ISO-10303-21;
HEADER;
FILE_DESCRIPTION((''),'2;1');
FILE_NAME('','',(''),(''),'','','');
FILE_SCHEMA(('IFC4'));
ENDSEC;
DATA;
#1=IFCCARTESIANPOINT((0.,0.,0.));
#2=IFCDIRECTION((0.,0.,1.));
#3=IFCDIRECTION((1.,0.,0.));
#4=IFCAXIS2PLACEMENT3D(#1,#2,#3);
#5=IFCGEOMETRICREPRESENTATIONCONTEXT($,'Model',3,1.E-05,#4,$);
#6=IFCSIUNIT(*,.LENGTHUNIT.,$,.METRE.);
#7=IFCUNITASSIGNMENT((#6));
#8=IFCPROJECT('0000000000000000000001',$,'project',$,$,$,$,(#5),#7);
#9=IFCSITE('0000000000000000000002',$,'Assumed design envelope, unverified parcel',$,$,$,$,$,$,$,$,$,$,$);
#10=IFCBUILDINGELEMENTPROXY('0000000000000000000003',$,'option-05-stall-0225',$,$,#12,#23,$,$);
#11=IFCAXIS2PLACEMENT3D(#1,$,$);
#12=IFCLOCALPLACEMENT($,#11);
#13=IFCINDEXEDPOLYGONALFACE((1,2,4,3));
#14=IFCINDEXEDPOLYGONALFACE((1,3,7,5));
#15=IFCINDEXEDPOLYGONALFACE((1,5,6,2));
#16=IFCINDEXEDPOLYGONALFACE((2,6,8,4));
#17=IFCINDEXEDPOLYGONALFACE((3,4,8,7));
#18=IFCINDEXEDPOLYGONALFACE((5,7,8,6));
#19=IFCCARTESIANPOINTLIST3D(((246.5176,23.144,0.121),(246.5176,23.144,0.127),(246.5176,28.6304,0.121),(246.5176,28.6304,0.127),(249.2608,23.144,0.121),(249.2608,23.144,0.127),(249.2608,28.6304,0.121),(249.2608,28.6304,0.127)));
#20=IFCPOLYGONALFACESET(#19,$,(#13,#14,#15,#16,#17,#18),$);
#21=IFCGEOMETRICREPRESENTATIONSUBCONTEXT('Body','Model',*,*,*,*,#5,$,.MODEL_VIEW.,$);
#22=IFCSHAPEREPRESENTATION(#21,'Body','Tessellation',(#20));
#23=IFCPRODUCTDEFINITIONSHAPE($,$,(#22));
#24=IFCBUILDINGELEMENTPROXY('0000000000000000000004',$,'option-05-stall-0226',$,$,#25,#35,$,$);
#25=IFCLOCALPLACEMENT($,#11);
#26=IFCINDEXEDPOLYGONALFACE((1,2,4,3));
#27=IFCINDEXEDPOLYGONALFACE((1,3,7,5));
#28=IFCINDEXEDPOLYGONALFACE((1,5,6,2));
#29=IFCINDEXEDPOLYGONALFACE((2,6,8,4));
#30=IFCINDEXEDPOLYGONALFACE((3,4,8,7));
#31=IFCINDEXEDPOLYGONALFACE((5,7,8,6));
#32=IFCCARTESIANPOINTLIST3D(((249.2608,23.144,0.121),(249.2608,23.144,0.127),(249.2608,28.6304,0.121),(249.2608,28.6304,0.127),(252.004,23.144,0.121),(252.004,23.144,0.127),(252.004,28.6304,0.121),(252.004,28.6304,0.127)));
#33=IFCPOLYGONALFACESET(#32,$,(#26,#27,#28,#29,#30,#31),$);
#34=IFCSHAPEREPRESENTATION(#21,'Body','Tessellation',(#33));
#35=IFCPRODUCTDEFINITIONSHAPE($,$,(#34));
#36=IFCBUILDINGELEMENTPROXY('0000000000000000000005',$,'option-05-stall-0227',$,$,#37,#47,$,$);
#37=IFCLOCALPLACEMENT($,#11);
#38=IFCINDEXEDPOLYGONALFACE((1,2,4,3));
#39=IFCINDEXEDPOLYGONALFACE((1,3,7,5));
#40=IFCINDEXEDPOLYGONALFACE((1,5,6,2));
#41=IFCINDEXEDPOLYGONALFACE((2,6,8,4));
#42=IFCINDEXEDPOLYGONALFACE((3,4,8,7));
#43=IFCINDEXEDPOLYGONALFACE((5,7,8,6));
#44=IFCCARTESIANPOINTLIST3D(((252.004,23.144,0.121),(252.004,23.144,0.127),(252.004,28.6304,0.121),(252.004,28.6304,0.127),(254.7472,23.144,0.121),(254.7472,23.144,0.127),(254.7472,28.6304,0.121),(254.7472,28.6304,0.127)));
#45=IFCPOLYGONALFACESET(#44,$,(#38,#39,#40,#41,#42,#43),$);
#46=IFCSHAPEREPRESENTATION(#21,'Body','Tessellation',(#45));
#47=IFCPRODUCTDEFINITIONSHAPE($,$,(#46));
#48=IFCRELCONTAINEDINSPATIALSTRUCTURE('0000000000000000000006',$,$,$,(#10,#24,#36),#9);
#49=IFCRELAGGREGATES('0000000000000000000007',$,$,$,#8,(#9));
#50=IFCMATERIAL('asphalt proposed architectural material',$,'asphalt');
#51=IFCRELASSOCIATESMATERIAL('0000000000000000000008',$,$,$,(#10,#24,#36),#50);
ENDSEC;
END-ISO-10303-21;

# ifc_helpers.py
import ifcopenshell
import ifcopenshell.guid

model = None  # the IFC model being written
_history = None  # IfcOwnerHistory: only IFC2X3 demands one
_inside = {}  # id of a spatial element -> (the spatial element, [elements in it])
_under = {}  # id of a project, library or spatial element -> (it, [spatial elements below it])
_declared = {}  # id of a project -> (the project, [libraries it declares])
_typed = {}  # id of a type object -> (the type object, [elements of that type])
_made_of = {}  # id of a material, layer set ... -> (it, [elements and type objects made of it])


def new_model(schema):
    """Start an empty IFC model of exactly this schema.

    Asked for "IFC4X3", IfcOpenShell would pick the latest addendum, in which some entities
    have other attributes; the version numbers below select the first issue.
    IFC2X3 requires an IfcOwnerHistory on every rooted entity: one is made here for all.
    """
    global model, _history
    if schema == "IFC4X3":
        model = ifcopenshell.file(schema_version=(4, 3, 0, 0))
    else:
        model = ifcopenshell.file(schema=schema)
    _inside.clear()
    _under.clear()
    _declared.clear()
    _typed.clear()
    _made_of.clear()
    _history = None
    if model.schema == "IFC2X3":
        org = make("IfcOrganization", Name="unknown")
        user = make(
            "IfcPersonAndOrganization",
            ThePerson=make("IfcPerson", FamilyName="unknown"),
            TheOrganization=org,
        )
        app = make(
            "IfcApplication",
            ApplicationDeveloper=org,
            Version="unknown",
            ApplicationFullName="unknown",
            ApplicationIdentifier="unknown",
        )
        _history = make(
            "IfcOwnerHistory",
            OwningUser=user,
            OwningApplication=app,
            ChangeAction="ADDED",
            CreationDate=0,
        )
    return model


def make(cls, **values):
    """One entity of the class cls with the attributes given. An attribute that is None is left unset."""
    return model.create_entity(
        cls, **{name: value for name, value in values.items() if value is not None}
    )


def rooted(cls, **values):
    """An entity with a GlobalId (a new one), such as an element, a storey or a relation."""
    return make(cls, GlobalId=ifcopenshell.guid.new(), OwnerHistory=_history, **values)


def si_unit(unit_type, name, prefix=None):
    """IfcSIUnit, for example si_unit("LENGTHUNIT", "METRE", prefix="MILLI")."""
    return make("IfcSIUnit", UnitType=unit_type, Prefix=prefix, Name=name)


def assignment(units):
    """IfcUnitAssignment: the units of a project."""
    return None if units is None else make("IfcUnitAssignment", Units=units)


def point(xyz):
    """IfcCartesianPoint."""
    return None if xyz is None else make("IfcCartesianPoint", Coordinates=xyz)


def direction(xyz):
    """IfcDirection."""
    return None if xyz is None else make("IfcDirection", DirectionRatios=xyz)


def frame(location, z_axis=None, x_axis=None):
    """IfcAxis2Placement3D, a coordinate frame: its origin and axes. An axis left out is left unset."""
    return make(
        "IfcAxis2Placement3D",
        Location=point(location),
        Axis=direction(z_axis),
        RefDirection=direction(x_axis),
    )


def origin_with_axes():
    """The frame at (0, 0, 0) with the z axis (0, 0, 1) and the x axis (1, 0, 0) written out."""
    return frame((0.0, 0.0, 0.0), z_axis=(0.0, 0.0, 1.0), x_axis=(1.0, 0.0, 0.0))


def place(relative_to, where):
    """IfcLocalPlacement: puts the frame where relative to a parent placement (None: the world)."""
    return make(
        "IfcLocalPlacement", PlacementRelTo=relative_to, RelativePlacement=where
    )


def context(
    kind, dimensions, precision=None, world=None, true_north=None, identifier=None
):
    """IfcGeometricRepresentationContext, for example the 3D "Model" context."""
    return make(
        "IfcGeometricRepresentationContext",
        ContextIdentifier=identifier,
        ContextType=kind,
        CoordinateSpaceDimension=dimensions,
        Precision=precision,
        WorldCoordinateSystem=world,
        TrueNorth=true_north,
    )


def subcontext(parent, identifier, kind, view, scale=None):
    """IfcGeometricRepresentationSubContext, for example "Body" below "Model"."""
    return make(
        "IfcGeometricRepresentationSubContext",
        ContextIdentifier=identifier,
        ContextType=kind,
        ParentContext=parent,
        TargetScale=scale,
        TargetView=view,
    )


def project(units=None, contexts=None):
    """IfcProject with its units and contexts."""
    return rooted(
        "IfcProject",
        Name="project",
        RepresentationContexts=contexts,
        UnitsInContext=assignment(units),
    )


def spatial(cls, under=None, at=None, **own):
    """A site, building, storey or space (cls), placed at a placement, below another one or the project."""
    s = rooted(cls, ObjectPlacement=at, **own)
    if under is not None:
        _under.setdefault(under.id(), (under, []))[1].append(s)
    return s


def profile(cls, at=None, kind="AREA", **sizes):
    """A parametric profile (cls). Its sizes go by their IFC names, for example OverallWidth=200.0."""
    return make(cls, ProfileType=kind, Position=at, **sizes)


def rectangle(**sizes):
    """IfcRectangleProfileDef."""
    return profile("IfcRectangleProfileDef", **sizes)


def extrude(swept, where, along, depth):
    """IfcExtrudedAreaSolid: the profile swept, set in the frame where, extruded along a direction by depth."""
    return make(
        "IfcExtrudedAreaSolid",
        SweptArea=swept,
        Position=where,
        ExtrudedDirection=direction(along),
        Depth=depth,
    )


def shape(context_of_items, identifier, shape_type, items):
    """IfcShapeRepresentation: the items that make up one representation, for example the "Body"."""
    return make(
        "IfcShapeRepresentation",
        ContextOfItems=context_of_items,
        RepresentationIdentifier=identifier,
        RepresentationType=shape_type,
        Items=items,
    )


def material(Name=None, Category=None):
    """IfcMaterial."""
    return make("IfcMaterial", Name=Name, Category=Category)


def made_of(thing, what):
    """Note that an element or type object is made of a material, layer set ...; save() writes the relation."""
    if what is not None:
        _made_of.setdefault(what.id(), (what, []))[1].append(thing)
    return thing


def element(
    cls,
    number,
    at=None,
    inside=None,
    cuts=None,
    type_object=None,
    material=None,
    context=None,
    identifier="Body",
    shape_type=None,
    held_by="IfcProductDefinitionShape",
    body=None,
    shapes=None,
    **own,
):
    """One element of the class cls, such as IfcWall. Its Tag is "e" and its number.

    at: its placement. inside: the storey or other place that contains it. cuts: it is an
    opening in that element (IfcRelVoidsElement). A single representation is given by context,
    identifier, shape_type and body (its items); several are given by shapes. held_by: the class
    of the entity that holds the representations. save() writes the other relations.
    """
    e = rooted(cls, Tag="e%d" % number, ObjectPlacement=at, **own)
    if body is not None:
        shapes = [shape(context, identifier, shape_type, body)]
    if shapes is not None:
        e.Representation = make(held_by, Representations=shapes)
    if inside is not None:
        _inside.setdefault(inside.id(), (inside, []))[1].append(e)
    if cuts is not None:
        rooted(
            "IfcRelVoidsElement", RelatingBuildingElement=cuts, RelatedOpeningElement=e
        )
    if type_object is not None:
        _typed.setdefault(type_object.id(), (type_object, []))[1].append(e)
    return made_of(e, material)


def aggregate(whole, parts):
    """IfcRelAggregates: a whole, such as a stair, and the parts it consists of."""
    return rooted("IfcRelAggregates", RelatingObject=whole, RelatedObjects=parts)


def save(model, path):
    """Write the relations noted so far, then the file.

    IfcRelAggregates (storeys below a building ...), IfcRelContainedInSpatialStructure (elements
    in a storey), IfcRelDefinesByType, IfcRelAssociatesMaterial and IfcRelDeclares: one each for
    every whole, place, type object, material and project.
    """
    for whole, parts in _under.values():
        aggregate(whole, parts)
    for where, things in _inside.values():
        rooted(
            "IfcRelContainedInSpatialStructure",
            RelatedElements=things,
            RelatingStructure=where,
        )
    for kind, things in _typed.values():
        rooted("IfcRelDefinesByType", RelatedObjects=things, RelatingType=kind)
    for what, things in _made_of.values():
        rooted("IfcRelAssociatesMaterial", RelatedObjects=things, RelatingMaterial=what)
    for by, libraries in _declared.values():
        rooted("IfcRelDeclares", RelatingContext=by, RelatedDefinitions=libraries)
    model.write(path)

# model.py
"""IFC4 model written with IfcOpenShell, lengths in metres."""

from ifc_helpers import new_model, si_unit, frame, origin_with_axes, place, context, subcontext, project, spatial, rectangle, extrude, material, element, save


model = new_model("IFC4")

# Units and contexts
model_context = context("Model", 3, precision=1e-05, world=origin_with_axes())
body_context = subcontext(model_context, "Body", "Model", "MODEL_VIEW")
ifc_project = project(units=[si_unit("LENGTHUNIT", "METRE")], contexts=[model_context])

# Site
site = spatial("IfcSite", under=ifc_project, Name="Assumed design envelope, unverified parcel")

# Building element proxies
ifc_material = material(Name="asphalt proposed architectural material", Category="asphalt")
for number, where, z_axis, x_axis, name in (
    (1, (247.8892, 25.8872, 0.121), (0.0, 0.0, 1.0), (1.0, 0.0, 0.0), "option-05-stall-0225"),
    (2, (250.6324, 25.8872, 0.121), (0.0, 0.0, 1.0), (1.0, 0.0, 0.0), "option-05-stall-0226"),
    (3, (253.3756, 25.8872, 0.121), (0.0, 0.0, 1.0), (1.0, 0.0, 0.0), "option-05-stall-0227"),
):
    element("IfcBuildingElementProxy", number, at=place(None, frame(where, z_axis=z_axis, x_axis=x_axis)), inside=site, material=ifc_material, Name=name, context=body_context, shape_type="SweptSolid", body=[
        extrude(rectangle(XDim=2.7432, YDim=5.4864), origin_with_axes(), (0.0, 0.0, 1.0), 0.006),
    ])

save(model, "model.ifc")
